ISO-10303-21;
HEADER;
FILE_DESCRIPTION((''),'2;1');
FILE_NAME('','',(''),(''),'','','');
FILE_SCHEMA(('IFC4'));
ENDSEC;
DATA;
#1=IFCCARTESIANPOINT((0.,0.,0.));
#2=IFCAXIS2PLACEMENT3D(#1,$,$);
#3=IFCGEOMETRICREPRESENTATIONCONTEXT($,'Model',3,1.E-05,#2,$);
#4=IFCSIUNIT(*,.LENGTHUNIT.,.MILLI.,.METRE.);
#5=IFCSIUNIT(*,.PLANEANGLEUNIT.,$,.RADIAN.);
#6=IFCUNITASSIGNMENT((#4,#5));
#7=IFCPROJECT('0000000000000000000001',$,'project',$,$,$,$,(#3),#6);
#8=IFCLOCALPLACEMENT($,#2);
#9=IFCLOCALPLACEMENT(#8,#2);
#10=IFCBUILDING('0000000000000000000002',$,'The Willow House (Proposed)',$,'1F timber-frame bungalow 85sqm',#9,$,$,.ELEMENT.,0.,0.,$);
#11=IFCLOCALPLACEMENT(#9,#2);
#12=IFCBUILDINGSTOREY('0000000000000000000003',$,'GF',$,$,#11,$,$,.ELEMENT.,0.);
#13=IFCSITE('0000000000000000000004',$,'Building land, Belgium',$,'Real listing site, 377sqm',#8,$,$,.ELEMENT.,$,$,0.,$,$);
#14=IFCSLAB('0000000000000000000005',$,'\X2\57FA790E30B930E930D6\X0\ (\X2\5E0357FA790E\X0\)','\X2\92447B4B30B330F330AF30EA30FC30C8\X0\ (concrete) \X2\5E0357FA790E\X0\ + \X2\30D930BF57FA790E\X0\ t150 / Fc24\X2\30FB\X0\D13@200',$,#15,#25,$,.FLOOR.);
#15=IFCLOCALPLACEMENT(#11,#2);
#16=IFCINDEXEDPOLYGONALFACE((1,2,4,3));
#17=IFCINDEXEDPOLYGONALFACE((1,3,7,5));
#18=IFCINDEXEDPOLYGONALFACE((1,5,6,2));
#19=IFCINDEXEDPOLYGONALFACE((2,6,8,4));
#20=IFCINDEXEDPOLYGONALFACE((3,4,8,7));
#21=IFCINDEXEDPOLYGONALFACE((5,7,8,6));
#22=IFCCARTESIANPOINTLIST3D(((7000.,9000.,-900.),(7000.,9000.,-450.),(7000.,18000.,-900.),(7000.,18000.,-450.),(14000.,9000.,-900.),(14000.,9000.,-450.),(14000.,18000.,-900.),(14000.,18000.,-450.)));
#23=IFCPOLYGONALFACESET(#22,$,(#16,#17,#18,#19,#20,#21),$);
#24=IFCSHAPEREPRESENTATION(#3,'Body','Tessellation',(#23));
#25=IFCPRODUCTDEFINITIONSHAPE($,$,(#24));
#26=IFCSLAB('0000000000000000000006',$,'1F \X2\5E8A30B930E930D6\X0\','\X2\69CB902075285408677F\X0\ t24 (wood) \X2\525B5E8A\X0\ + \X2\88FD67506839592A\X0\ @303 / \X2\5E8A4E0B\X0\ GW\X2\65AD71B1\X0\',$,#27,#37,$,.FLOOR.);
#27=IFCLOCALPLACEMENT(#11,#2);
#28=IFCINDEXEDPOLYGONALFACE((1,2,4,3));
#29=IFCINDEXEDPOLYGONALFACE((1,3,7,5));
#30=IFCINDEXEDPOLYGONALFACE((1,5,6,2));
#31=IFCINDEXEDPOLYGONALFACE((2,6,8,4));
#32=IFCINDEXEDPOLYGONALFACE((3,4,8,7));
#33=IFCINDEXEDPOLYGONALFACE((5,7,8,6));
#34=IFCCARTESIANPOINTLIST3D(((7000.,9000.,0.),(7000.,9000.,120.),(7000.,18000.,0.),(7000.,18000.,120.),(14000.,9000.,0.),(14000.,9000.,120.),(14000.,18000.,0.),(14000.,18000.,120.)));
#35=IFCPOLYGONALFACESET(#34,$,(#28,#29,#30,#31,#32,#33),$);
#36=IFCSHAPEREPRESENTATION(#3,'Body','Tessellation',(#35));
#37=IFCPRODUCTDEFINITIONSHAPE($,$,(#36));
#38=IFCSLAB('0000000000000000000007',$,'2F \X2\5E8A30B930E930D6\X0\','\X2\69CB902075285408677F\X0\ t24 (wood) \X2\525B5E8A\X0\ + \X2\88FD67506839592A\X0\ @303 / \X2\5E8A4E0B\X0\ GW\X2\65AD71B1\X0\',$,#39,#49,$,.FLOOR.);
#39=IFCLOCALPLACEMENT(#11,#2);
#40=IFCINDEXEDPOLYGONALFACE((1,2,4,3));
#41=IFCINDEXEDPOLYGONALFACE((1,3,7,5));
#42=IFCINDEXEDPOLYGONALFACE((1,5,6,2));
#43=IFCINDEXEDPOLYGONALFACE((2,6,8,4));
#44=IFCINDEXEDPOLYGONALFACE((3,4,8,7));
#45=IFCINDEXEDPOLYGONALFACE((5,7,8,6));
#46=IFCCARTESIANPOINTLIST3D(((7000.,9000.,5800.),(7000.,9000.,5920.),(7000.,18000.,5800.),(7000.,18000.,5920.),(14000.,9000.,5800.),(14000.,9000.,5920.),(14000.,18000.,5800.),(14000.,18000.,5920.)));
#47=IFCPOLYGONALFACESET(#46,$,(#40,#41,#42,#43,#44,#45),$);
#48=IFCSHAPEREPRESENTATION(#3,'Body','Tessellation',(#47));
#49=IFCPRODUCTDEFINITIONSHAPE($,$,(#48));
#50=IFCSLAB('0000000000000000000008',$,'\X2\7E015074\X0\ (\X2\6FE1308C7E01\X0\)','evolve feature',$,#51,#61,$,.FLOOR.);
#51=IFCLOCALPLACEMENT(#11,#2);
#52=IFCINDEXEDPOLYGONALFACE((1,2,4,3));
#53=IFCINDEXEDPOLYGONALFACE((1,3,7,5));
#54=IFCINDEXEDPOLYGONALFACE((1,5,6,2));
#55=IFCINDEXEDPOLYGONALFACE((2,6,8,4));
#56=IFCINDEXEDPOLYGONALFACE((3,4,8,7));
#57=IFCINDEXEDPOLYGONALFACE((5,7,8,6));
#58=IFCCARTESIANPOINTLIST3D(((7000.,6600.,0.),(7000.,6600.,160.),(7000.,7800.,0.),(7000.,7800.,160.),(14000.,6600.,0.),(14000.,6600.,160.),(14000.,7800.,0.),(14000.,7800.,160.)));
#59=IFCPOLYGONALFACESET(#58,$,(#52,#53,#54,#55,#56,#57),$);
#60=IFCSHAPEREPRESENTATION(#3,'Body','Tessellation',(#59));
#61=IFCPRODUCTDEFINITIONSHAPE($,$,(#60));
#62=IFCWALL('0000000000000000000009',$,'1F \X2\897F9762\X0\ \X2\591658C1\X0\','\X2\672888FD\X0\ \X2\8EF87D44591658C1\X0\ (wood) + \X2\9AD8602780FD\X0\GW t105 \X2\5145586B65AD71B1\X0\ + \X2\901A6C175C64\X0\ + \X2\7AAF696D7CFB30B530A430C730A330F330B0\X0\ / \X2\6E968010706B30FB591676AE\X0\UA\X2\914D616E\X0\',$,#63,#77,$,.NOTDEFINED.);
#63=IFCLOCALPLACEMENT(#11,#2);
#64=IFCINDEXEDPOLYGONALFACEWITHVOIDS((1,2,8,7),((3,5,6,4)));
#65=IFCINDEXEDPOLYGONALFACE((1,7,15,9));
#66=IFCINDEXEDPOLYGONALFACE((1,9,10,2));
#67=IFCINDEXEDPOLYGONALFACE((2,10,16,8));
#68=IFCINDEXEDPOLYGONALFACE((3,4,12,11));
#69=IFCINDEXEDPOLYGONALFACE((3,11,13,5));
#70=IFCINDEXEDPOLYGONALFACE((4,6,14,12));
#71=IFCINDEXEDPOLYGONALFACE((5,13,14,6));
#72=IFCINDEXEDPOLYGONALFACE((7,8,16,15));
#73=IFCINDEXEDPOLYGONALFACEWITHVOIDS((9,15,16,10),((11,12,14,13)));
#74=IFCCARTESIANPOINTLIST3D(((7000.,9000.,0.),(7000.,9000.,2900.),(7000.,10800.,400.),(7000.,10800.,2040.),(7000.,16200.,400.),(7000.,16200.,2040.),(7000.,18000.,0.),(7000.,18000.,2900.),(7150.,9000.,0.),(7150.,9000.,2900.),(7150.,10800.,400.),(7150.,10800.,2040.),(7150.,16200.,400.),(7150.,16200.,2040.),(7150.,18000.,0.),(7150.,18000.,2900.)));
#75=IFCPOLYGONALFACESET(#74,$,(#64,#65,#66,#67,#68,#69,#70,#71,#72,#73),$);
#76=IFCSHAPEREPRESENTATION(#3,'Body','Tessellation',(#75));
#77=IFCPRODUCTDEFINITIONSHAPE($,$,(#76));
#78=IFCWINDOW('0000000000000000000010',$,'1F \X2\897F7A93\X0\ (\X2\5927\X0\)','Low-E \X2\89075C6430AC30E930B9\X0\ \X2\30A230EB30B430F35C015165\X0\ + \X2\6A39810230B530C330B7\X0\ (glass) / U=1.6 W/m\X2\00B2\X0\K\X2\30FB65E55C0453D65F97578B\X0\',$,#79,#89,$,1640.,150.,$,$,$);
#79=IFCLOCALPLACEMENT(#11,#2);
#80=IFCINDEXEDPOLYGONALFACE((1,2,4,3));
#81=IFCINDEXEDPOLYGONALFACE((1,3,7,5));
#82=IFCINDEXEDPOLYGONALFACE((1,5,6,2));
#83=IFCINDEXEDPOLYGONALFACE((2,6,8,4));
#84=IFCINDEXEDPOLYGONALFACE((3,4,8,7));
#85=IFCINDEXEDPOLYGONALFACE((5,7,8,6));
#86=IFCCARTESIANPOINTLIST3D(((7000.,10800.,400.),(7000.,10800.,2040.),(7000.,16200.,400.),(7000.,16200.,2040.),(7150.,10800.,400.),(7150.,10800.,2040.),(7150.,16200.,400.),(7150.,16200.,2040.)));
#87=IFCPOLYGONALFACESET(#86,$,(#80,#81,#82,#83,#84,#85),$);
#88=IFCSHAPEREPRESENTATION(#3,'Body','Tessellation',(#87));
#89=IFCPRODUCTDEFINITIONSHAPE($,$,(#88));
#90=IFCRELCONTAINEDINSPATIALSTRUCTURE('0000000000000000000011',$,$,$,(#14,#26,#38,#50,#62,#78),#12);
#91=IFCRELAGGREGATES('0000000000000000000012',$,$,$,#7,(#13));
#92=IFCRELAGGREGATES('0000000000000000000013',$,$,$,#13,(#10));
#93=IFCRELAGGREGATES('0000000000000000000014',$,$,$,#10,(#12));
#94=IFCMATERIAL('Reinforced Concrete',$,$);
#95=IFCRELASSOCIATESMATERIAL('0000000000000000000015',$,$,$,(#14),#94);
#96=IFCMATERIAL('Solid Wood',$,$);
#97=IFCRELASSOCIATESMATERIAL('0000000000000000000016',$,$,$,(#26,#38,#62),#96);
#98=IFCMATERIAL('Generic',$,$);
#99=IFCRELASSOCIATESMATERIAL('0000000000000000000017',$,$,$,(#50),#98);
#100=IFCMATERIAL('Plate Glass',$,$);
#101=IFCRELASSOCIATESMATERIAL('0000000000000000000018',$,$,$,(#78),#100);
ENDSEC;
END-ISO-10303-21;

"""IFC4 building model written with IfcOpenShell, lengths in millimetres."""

from ifc_helpers import new_model, si_unit, frame, frame_2d, origin, place, context, project, spatial, rectangle, extrude, material, element, fill, save


model = new_model("IFC4")

# Units and contexts
model_context = context("Model", 3, precision=1e-05, world=origin())
ifc_project = project(units=[si_unit("LENGTHUNIT", "METRE", prefix="MILLI"), si_unit("PLANEANGLEUNIT", "RADIAN")], contexts=[model_context])

# Site, building, storey
site_placement = place(None, origin())
site = spatial("IfcSite", under=ifc_project, at=site_placement, Name="Building land, Belgium", ObjectType="Real listing site, 377sqm", CompositionType="ELEMENT", RefElevation=0.0)
building_placement = place(site_placement, origin())
building = spatial("IfcBuilding", under=site, at=building_placement, Name="The Willow House (Proposed)", ObjectType="1F timber-frame bungalow 85sqm", CompositionType="ELEMENT", ElevationOfRefHeight=0.0, ElevationOfTerrain=0.0)
storey_placement = place(building_placement, origin())
storey = spatial("IfcBuildingStorey", under=building, at=storey_placement, Name="GF", CompositionType="ELEMENT", Elevation=0.0)

# Slabs
ifc_material_1 = material(Name="Reinforced Concrete")
slab_1_placement = place(storey_placement, frame((3500.0, 4500.0, -450.0)))
element("IfcSlab", 1, at=slab_1_placement, inside=storey, material=ifc_material_1, Name="基礎スラブ (布基礎)", Description="鉄筋コンクリート (concrete) 布基礎 + ベタ基礎 t150 / Fc24・D13@200", PredefinedType="FLOOR", context=model_context, shape_type="SweptSolid", body=[
    extrude(rectangle(XDim=7000.0, YDim=9000.0, at=frame_2d((3500.0, 4500.0))), frame((3500.0, 4500.0, -450.0)), (0.0, 0.0, 1.0), 450.0),
])
ifc_material_2 = material(Name="Solid Wood")
slab_2_placement = place(storey_placement, frame((3500.0, 4500.0, 0.0)))
element("IfcSlab", 2, at=slab_2_placement, inside=storey, material=ifc_material_2, Name="1F 床スラブ", Description="構造用合板 t24 (wood) 剛床 + 製材根太 @303 / 床下 GW断熱", PredefinedType="FLOOR", context=model_context, shape_type="SweptSolid", body=[
    extrude(rectangle(XDim=7000.0, YDim=9000.0, at=frame_2d((3500.0, 4500.0))), frame((3500.0, 4500.0, 0.0)), (0.0, 0.0, 1.0), 120.0),
])
slab_3_placement = place(storey_placement, frame((3500.0, 4500.0, 2900.0)))
element("IfcSlab", 3, at=slab_3_placement, inside=storey, material=ifc_material_2, Name="2F 床スラブ", Description="構造用合板 t24 (wood) 剛床 + 製材根太 @303 / 床下 GW断熱", PredefinedType="FLOOR", context=model_context, shape_type="SweptSolid", body=[
    extrude(rectangle(XDim=7000.0, YDim=9000.0, at=frame_2d((3500.0, 4500.0))), frame((3500.0, 4500.0, 2900.0)), (0.0, 0.0, 1.0), 120.0),
])
ifc_material_3 = material(Name="Generic")
slab_4_placement = place(storey_placement, frame((3500.0, 3300.0, 0.0)))
element("IfcSlab", 4, at=slab_4_placement, inside=storey, material=ifc_material_3, Name="縁側 (濡れ縁)", Description="evolve feature", PredefinedType="FLOOR", context=model_context, shape_type="SweptSolid", body=[
    extrude(rectangle(XDim=7000.0, YDim=1200.0, at=frame_2d((3500.0, 600.0))), frame((3500.0, 3300.0, 0.0)), (0.0, 0.0, 1.0), 160.0),
])

# Shared definitions
ifc_material_4 = material(Name="Plate Glass")

# Wall, opening, window
wall_1_placement = place(storey_placement, frame((3500.0, 4500.0, 0.0)))
wall_1 = element("IfcWall", 5, at=wall_1_placement, inside=storey, material=ifc_material_2, Name="1F 西面 外壁", Description="木製 軸組外壁 (wood) + 高性能GW t105 充填断熱 + 通気層 + 窯業系サイディング / 準耐火・外皮UA配慮", PredefinedType="NOTDEFINED", context=model_context, shape_type="SweptSolid", body=[
    extrude(rectangle(XDim=150.0, YDim=9000.0, at=frame_2d((75.0, 4500.0))), frame((3500.0, 4500.0, 0.0)), (0.0, 0.0, 1.0), 2900.0),
])
opening_1_placement = place(storey_placement, frame((3500.0, 5400.0, 200.0)))
opening_1 = element("IfcOpeningElement", 6, at=opening_1_placement, cuts=wall_1, PredefinedType="NOTDEFINED", context=model_context, shape_type="SweptSolid", body=[
    extrude(rectangle(XDim=150.0, YDim=5400.0, at=frame_2d((75.0, 2700.0))), frame((3500.0, 5400.0, 200.0)), (0.0, 0.0, 1.0), 1640.0),
])
window_1_placement = place(storey_placement, frame((3500.0, 5400.0, 200.0)))
window_1 = element("IfcWindow", 7, at=window_1_placement, inside=storey, material=ifc_material_4, Name="1F 西窓 (大)", Description="Low-E 複層ガラス アルゴン封入 + 樹脂サッシ (glass) / U=1.6 W/m²K・日射取得型", OverallHeight=1640.0, OverallWidth=150.0, context=model_context, shape_type="SweptSolid", body=[
    extrude(rectangle(XDim=150.0, YDim=5400.0, at=frame_2d((75.0, 2700.0))), frame((3500.0, 5400.0, 200.0)), (0.0, 0.0, 1.0), 1640.0),
])
fill(opening_1, window_1)

save(model, "model.ifc")
